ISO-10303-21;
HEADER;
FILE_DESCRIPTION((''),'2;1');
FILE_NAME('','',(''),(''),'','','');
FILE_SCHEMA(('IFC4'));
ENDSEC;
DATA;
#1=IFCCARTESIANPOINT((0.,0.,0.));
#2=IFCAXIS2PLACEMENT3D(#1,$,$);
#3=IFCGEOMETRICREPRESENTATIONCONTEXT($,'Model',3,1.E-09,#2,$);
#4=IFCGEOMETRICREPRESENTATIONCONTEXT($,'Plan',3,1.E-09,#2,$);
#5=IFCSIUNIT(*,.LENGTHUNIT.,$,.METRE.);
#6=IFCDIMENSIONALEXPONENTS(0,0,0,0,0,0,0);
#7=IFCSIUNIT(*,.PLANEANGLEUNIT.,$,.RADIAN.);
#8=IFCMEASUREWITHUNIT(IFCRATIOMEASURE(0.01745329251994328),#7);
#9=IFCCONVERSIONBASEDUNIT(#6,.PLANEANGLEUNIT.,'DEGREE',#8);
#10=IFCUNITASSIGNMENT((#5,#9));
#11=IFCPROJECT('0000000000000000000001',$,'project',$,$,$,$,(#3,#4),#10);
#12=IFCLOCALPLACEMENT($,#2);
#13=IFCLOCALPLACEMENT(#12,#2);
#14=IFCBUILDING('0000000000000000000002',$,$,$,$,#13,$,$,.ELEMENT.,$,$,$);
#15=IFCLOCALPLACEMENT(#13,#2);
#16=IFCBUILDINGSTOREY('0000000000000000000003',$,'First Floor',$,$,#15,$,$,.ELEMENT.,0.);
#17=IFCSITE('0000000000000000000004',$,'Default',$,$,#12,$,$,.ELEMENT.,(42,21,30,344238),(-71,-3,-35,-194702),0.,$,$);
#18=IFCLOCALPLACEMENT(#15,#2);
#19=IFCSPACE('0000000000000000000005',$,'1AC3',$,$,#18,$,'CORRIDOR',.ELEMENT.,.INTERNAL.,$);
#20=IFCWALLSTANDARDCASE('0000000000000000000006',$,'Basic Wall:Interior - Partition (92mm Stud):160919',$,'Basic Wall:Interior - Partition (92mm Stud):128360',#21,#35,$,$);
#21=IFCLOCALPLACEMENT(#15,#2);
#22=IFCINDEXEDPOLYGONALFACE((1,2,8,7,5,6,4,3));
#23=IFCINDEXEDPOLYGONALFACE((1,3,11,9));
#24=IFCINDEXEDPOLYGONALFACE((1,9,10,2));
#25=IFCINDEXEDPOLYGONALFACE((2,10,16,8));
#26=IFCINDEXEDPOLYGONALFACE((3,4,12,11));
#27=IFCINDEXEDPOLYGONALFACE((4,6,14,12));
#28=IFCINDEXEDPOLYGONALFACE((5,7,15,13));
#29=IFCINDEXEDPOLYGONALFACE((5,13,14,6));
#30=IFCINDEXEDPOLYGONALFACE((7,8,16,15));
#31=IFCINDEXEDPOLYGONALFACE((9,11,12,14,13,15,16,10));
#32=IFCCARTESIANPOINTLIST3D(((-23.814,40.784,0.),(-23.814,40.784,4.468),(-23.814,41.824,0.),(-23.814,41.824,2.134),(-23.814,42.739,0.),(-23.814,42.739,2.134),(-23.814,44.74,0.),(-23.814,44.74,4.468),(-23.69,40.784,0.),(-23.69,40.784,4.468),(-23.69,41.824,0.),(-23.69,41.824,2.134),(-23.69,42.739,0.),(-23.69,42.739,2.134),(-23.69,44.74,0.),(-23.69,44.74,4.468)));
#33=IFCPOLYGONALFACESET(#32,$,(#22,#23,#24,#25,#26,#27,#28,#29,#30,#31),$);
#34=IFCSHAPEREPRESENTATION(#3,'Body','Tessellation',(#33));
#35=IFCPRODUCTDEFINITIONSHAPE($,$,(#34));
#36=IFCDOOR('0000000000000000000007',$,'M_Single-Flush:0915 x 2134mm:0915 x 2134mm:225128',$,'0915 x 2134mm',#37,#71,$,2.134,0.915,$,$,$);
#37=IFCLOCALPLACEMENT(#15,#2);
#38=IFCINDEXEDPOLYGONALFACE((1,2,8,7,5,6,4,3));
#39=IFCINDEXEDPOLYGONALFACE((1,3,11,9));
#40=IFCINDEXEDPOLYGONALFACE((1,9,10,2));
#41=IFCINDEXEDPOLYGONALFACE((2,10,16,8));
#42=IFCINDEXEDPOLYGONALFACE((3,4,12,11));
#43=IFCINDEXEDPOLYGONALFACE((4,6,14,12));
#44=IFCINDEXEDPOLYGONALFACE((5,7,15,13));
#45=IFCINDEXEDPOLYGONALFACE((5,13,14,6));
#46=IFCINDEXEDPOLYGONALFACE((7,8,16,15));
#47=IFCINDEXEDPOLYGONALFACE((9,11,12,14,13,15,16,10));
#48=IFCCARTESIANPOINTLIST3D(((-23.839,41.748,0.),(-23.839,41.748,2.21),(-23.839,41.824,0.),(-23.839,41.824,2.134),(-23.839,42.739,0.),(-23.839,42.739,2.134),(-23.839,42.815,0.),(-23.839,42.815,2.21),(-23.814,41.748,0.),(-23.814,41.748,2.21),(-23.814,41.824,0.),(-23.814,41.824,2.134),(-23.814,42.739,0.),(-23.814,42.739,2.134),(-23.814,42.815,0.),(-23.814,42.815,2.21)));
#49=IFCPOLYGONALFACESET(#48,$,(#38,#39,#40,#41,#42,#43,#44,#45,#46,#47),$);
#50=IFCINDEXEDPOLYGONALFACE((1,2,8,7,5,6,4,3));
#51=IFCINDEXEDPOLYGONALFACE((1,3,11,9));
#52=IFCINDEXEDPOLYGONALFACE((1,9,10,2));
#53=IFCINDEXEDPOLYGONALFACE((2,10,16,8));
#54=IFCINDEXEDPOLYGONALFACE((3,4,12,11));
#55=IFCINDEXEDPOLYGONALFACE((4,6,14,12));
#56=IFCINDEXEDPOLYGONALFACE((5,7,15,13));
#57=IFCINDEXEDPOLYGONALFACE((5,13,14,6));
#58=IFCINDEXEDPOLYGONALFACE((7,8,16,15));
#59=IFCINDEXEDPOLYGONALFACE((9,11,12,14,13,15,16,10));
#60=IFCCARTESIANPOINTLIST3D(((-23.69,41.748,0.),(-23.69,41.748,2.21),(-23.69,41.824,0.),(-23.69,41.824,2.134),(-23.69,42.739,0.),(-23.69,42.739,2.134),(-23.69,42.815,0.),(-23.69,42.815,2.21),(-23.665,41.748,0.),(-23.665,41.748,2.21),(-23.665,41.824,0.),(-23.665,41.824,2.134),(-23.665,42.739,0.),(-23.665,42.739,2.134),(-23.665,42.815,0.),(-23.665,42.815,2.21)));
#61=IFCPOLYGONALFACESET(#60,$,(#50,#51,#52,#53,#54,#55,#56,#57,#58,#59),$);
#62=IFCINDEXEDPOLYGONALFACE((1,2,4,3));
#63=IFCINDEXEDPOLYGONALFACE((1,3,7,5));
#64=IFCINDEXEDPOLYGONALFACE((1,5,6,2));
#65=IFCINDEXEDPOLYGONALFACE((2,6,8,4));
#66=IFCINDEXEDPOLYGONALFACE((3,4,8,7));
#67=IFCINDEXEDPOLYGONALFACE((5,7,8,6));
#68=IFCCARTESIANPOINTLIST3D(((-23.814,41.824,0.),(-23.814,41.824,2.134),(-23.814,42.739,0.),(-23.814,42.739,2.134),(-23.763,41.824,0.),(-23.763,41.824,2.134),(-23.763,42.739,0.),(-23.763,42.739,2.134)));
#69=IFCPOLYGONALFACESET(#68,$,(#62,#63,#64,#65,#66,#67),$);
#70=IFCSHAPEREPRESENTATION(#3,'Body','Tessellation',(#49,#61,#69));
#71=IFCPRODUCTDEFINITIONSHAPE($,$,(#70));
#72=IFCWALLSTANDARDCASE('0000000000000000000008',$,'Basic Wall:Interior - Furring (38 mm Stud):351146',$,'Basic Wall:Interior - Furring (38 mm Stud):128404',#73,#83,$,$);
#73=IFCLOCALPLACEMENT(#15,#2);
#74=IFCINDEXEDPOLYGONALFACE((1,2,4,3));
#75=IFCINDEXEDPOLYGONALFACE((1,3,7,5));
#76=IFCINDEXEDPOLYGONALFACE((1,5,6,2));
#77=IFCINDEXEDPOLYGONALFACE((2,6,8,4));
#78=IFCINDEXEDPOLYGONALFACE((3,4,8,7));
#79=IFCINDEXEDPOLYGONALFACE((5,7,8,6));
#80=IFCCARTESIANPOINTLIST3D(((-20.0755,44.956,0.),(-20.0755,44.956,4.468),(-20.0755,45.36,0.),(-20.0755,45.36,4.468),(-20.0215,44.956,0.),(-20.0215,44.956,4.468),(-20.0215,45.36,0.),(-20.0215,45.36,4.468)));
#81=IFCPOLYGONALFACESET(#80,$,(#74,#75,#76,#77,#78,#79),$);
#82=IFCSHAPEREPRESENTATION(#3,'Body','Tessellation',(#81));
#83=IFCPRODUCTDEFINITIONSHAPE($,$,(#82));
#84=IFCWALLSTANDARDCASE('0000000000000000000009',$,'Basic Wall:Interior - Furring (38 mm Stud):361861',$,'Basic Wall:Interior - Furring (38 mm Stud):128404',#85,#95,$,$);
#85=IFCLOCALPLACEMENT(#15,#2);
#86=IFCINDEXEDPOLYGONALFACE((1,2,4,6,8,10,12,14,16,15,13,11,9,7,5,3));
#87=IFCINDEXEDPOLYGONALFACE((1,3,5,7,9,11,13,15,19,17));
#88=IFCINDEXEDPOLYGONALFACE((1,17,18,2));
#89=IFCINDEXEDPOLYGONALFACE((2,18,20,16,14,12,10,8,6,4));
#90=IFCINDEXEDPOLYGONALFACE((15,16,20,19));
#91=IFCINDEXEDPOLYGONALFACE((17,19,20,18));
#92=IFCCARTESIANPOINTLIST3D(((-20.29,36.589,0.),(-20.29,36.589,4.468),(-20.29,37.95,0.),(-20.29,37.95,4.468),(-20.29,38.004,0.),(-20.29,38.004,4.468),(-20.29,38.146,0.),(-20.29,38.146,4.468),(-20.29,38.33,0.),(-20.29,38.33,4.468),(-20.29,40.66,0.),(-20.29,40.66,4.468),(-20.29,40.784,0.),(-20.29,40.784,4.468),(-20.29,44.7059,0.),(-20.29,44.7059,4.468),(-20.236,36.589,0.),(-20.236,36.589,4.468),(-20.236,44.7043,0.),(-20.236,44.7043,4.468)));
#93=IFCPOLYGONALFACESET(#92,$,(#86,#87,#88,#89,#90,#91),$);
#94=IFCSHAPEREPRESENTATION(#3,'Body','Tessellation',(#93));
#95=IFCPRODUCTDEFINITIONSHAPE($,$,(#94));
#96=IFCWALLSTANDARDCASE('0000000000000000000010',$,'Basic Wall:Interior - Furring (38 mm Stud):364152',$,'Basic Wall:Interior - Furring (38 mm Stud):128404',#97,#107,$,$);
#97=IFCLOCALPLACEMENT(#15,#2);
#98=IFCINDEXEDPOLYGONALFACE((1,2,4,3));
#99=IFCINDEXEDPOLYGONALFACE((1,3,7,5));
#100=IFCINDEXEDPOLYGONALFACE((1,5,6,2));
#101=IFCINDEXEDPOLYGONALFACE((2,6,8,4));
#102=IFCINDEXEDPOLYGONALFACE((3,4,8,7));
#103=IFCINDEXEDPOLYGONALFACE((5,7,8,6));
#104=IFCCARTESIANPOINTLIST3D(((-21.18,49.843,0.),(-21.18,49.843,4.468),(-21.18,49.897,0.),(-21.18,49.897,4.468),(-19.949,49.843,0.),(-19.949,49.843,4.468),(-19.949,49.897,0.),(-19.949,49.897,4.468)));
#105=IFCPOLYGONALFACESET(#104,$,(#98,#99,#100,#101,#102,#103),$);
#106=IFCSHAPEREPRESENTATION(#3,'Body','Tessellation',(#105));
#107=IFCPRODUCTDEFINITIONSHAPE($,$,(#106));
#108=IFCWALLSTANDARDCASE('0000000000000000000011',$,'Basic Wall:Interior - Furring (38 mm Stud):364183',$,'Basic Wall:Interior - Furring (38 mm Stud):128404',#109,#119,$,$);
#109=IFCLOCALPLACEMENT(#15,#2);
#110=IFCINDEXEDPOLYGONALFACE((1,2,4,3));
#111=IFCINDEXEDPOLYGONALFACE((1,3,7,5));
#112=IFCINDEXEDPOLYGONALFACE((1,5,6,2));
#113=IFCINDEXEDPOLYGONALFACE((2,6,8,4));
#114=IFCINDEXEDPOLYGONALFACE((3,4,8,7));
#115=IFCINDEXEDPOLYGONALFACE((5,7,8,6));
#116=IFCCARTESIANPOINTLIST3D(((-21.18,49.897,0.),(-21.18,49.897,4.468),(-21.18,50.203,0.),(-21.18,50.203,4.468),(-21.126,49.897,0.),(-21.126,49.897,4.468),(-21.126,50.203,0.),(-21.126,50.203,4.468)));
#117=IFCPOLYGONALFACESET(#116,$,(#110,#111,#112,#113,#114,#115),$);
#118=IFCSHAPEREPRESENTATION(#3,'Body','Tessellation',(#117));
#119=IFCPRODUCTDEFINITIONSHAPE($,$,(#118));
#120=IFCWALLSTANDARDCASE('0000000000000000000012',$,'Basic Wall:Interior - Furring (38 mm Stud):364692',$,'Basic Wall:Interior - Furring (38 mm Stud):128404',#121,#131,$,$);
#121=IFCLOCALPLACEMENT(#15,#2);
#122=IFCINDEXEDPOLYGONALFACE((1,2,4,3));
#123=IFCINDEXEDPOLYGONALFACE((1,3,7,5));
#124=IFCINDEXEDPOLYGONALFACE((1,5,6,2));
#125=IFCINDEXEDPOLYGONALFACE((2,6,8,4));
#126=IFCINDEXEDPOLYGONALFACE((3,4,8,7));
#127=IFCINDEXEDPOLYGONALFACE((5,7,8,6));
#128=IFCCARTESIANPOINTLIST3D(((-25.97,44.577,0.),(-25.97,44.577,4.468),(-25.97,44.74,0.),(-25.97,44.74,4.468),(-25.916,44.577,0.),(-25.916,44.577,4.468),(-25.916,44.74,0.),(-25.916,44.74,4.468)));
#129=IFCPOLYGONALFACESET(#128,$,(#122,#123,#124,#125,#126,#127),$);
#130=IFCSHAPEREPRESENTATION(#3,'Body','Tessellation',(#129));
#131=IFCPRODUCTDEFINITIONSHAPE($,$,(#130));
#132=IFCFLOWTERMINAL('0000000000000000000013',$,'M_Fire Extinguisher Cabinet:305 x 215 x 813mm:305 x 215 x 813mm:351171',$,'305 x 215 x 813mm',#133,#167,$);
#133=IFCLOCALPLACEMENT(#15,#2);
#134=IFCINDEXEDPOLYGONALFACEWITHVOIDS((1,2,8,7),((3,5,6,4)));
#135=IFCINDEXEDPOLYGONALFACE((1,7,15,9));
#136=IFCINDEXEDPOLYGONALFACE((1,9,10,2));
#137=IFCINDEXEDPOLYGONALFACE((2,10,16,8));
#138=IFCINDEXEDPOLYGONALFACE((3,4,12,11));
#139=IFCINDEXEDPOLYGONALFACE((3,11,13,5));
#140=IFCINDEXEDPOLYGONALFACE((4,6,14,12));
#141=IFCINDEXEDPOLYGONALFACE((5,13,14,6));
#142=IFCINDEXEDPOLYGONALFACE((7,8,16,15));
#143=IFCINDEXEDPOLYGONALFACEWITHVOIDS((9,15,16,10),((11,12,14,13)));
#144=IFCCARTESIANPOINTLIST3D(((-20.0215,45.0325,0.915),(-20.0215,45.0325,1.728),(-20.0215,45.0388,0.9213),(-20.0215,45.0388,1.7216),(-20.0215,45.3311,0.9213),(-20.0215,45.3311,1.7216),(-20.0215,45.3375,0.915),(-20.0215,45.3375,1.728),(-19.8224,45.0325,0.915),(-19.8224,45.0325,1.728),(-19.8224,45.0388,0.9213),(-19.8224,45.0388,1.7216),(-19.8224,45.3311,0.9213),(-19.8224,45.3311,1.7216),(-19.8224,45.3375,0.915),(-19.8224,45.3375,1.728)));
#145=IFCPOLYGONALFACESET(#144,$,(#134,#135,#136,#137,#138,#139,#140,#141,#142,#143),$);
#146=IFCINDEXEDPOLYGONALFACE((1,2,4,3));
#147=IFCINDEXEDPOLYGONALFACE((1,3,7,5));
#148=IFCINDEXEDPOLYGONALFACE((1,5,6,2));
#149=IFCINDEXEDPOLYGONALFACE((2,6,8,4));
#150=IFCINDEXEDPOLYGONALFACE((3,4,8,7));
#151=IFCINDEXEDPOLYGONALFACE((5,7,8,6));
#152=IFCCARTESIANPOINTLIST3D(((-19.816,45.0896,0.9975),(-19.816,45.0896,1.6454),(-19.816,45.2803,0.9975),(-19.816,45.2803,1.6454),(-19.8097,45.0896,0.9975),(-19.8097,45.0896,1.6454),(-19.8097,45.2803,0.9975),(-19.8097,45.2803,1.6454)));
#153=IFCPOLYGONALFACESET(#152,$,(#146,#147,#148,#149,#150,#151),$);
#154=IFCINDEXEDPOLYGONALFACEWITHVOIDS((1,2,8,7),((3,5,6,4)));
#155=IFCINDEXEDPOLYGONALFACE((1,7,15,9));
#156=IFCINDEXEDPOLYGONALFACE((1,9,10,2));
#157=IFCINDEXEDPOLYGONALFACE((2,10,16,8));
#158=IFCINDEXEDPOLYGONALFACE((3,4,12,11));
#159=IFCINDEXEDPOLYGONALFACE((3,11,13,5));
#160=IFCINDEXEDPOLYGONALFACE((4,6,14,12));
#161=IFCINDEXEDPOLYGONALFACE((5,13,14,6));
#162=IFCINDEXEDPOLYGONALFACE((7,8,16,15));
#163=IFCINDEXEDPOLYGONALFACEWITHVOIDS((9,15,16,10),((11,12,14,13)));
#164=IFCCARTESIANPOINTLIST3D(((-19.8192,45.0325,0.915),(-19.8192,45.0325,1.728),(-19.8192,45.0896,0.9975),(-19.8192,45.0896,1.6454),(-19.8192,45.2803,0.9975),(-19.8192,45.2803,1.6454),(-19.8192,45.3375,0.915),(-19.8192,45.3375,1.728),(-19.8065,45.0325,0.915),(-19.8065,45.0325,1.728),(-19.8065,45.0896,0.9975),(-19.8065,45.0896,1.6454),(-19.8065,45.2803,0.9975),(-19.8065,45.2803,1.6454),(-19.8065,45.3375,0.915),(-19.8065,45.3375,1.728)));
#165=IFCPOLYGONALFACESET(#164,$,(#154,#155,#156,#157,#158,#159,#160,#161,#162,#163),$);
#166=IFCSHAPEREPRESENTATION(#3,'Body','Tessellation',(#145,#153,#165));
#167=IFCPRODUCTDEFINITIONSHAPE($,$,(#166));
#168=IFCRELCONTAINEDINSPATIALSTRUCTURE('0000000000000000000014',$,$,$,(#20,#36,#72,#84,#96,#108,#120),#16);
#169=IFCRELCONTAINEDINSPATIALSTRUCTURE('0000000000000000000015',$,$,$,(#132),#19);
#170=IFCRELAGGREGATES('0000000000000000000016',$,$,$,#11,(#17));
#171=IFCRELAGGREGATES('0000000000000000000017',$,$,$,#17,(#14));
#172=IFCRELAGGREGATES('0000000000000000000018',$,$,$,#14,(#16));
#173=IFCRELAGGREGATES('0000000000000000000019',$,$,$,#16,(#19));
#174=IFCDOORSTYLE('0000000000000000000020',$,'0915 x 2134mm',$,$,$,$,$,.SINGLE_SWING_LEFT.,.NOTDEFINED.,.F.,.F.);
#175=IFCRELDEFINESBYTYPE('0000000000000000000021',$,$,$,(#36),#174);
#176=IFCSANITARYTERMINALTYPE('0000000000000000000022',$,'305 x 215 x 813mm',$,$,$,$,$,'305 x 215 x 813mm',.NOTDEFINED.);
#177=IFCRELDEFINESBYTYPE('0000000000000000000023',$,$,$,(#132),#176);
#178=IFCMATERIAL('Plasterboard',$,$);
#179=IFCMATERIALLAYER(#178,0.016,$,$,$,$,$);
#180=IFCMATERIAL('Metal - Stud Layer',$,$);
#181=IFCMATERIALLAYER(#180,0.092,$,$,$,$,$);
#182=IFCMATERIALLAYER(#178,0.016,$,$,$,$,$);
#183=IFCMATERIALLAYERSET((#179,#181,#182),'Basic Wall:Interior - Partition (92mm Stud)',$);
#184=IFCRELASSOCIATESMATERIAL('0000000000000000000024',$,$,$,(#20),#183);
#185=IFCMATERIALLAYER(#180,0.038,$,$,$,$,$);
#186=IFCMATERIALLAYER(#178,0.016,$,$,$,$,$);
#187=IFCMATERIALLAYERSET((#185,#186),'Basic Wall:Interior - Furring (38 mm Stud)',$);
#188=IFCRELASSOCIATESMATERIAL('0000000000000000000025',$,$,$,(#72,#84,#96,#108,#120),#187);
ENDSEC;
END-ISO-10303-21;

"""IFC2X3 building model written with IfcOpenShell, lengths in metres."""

from ifc_helpers import new_model, entity, si_unit, converted_unit, frame, frame_2d, origin, origin_2d_with_axis, place, context, project, spatial, polyline, rectangle, outline, extrude, source, transform, mapped, material, layer, layer_set, layer_usage, type_object, type_shapes, element, fill, save


model = new_model("IFC2X3")

# Units and contexts
model_context = context("Model", 3, precision=1e-09, world=origin())
plan_context = context("Plan", 3, precision=1e-09, world=origin())
ifc_project = project(units=[si_unit("LENGTHUNIT", "METRE"), converted_unit("PLANEANGLEUNIT", "DEGREE", entity("IfcRatioMeasure", 0.01745329251994328), si_unit("PLANEANGLEUNIT", "RADIAN"), dimensions=[0, 0, 0, 0, 0, 0, 0])], contexts=[model_context, plan_context])

# Site, building, storey
site_placement = place(None, origin())
site = spatial("IfcSite", under=ifc_project, at=site_placement, Name="Default", CompositionType="ELEMENT", RefLatitude=(42, 21, 30, 344238), RefLongitude=(-71, -3, -35, -194702), RefElevation=0.0)
building_placement = place(site_placement, origin())
building = spatial("IfcBuilding", under=site, at=building_placement, CompositionType="ELEMENT")
storey_placement = place(building_placement, origin())
storey = spatial("IfcBuildingStorey", under=building, at=storey_placement, Name="First Floor", CompositionType="ELEMENT", Elevation=0.0)

# Shared definitions
ifc_material_1 = material(Name="Plasterboard")
ifc_layer_1 = layer(ifc_material_1, 0.016)
ifc_material_2 = material(Name="Metal - Stud Layer")
ifc_layer_2 = layer(ifc_material_2, 0.092)
ifc_layer_3 = layer(ifc_material_1, 0.016)
ifc_layer_set_1 = layer_set([ifc_layer_1, ifc_layer_2, ifc_layer_3], Name="Basic Wall:Interior - Partition (92mm Stud)")

# Shared definitions
ifc_layer_4 = layer(ifc_material_2, 0.038)
ifc_layer_5 = layer(ifc_material_1, 0.016)
ifc_layer_set_2 = layer_set([ifc_layer_4, ifc_layer_5], Name="Basic Wall:Interior - Furring (38 mm Stud)")

# Wall, opening, door
ifc_layer_usage_1 = layer_usage(ifc_layer_set_1, "AXIS2", "NEGATIVE", 0.062)
wall_1_placement = place(storey_placement, frame((-23.752, 44.74, 0.0), z_axis=(0.0, 0.0, 1.0), x_axis=(0.0, -1.0, 0.0)))
wall_1 = element("IfcWallStandardCase", 1, at=wall_1_placement, inside=storey, material=ifc_layer_usage_1, Name="Basic Wall:Interior - Partition (92mm Stud):160919", ObjectType="Basic Wall:Interior - Partition (92mm Stud):128360", context=model_context, shape_type="SweptSolid", body=[
    extrude(rectangle(XDim=3.956, YDim=0.124, at=frame_2d((1.978, 0.0), x_axis=(-1.0, 0.0))), origin(), (0.0, 0.0, 1.0), 4.468),
])
opening_1_placement = place(wall_1_placement, frame((2.916, 0.062, 0.0)))
opening_1 = element("IfcOpeningElement", 2, at=opening_1_placement, cuts=wall_1, ObjectType="Opening", context=model_context, shape_type="SweptSolid", body=[
    extrude(rectangle(XDim=0.915, YDim=2.134, at=frame_2d((1.067, 0.4575), x_axis=(0.0, -1.0))), frame((0.0, 0.0, 0.0), z_axis=(0.0, -1.0, 0.0), x_axis=(0.0, 0.0, 1.0)), (0.0, 0.0, 1.0), 0.124),
])
door_style_1 = type_object("IfcDoorStyle", Name="0915 x 2134mm", ConstructionType="NOTDEFINED", OperationType="SINGLE_SWING_LEFT", ParameterTakesPrecedence=False, Sizeable=False)
shared_shape_1 = source(origin(), model_context, "Body", "SweptSolid", [
    extrude(outline(polyline([(-0.5335, -1.124), (0.5335, -1.124), (0.5335, 1.086), (0.4575, 1.086), (0.4575, -1.048), (-0.4575, -1.048), (-0.4575, 1.086), (-0.5335, 1.086), (-0.5335, -1.124)])), frame((0.4575, 0.149, 1.086), z_axis=(0.0, -1.0, 0.0), x_axis=(-1.0, 0.0, 0.0)), (0.0, 0.0, 1.0), 0.025),
    extrude(outline(polyline([(-1.124, -0.5335), (1.086, -0.5335), (1.086, -0.4575), (-1.048, -0.4575), (-1.048, 0.4575), (1.086, 0.4575), (1.086, 0.5335), (-1.124, 0.5335), (-1.124, -0.5335)])), frame((0.4575, 0.0, 1.086), z_axis=(0.0, -1.0, 0.0), x_axis=(0.0, 0.0, -1.0)), (0.0, 0.0, 1.0), 0.025),
    extrude(rectangle(XDim=0.915, YDim=0.051, at=origin_2d_with_axis()), frame((0.4575, 0.0985, 0.0)), (0.0, 0.0, 1.0), 2.134),
])
type_shapes(door_style_1, [shared_shape_1])
door_1_placement = place(opening_1_placement, frame((0.0, 0.0, 0.0), z_axis=(0.0, 0.0, 1.0), x_axis=(-1.0, 0.0, 0.0)))
door_1 = element("IfcDoor", 3, at=door_1_placement, inside=storey, type_object=door_style_1, Name="M_Single-Flush:0915 x 2134mm:0915 x 2134mm:225128", ObjectType="0915 x 2134mm", OverallHeight=2.134, OverallWidth=0.915, context=model_context, shape_type="MappedRepresentation", body=[
    mapped(shared_shape_1, transform((0.0, 0.0, 0.0), scale=1.0)),
])
fill(opening_1, door_1)

# Walls
ifc_layer_usage_2 = layer_usage(ifc_layer_set_2, "AXIS2", "POSITIVE", -0.027)
wall_2_placement = place(storey_placement, frame((-20.0485, 45.36, 0.0), z_axis=(0.0, 0.0, 1.0), x_axis=(0.0, -1.0, 0.0)))
element("IfcWallStandardCase", 4, at=wall_2_placement, inside=storey, material=ifc_layer_usage_2, Name="Basic Wall:Interior - Furring (38 mm Stud):351146", ObjectType="Basic Wall:Interior - Furring (38 mm Stud):128404", context=model_context, shape_type="SweptSolid", body=[
    extrude(rectangle(XDim=0.404, YDim=0.054, at=frame_2d((0.202, 0.0), x_axis=(-1.0, 0.0))), origin(), (0.0, 0.0, 1.0), 4.468),
])
ifc_layer_usage_3 = layer_usage(ifc_layer_set_2, "AXIS2", "NEGATIVE", 0.027)
wall_3_placement = place(storey_placement, frame((-20.263, 44.7059, 0.0), z_axis=(0.0, 0.0, 1.0), x_axis=(0.0, -1.0, 0.0)))
element("IfcWallStandardCase", 5, at=wall_3_placement, inside=storey, material=ifc_layer_usage_3, Name="Basic Wall:Interior - Furring (38 mm Stud):361861", ObjectType="Basic Wall:Interior - Furring (38 mm Stud):128404", context=model_context, shape_type="SweptSolid", body=[
    extrude(outline(polyline([(8.1169, -0.027), (8.1169, 0.027), (0.0016, 0.027), (0.0, -0.027), (3.9219, -0.027), (4.0459, -0.027), (6.3759, -0.027), (6.5599, -0.027), (6.7019, -0.027), (6.7559, -0.027), (8.1169, -0.027)])), origin(), (0.0, 0.0, 1.0), 4.468),
])
ifc_layer_usage_4 = layer_usage(ifc_layer_set_2, "AXIS2", "POSITIVE", -0.027)
wall_4_placement = place(storey_placement, frame((-19.949, 49.87, 0.0), z_axis=(0.0, 0.0, 1.0), x_axis=(-1.0, 0.0, 0.0)))
element("IfcWallStandardCase", 6, at=wall_4_placement, inside=storey, material=ifc_layer_usage_4, Name="Basic Wall:Interior - Furring (38 mm Stud):364152", ObjectType="Basic Wall:Interior - Furring (38 mm Stud):128404", context=model_context, shape_type="SweptSolid", body=[
    extrude(rectangle(XDim=1.231, YDim=0.054, at=frame_2d((0.6155, 0.0), x_axis=(-1.0, 0.0))), origin(), (0.0, 0.0, 1.0), 4.468),
])
ifc_layer_usage_5 = layer_usage(ifc_layer_set_2, "AXIS2", "POSITIVE", -0.027)
wall_5_placement = place(storey_placement, frame((-21.153, 49.897, 0.0), z_axis=(0.0, 0.0, 1.0), x_axis=(0.0, 1.0, 0.0)))
element("IfcWallStandardCase", 7, at=wall_5_placement, inside=storey, material=ifc_layer_usage_5, Name="Basic Wall:Interior - Furring (38 mm Stud):364183", ObjectType="Basic Wall:Interior - Furring (38 mm Stud):128404", context=model_context, shape_type="SweptSolid", body=[
    extrude(rectangle(XDim=0.306, YDim=0.054, at=frame_2d((0.153, 0.0), x_axis=(-1.0, 0.0))), origin(), (0.0, 0.0, 1.0), 4.468),
])
ifc_layer_usage_6 = layer_usage(ifc_layer_set_2, "AXIS2", "NEGATIVE", 0.027)
wall_6_placement = place(storey_placement, frame((-25.943, 44.577, 0.0), z_axis=(0.0, 0.0, 1.0), x_axis=(0.0, 1.0, 0.0)))
element("IfcWallStandardCase", 8, at=wall_6_placement, inside=storey, material=ifc_layer_usage_6, Name="Basic Wall:Interior - Furring (38 mm Stud):364692", ObjectType="Basic Wall:Interior - Furring (38 mm Stud):128404", context=model_context, shape_type="SweptSolid", body=[
    extrude(rectangle(XDim=0.163, YDim=0.054, at=frame_2d((0.0815, 0.0), x_axis=(-1.0, 0.0))), origin(), (0.0, 0.0, 1.0), 4.468),
])

# Shared definitions
space_placement = place(storey_placement, origin())
space = spatial("IfcSpace", under=storey, at=space_placement, Name="1AC3", LongName="CORRIDOR", CompositionType="ELEMENT", InteriorOrExteriorSpace="INTERNAL")

# Flow terminal
sanitary_terminal_type = type_object("IfcSanitaryTerminalType", Name="305 x 215 x 813mm", ElementType="305 x 215 x 813mm", PredefinedType="NOTDEFINED")
shared_shape_2 = source(origin(), model_context, "Body", "SweptSolid", [
    extrude(outline(polyline([(-0.1525, -0.4065), (0.1525, -0.4065), (0.1525, 0.4065), (-0.1525, 0.4065), (-0.1525, -0.4065)]), holes=[polyline([(-0.1462, -0.4001), (-0.1462, 0.4002), (0.1462, 0.4002), (0.1462, -0.4001), (-0.1462, -0.4001)])]), frame((-0.1096, 0.027, 1.3215), z_axis=(0.0, 1.0, 0.0), x_axis=(1.0, 0.0, 0.0)), (0.0, 0.0, 1.0), 0.1991),
    extrude(rectangle(XDim=0.0064, YDim=0.1907, at=origin_2d_with_axis()), frame((-0.1096, 0.2356, 0.9975), z_axis=(0.0, 0.0, 1.0), x_axis=(0.0, -1.0, 0.0)), (0.0, 0.0, 1.0), 0.6479),
    extrude(outline(polyline([(-0.1525, -0.4065), (0.1525, -0.4065), (0.1525, 0.4065), (-0.1525, 0.4065), (-0.1525, -0.4065)]), holes=[polyline([(-0.0953, -0.3239), (-0.0953, 0.324), (0.0954, 0.324), (0.0954, -0.3239), (-0.0953, -0.3239)])]), frame((-0.1096, 0.2293, 1.3215), z_axis=(0.0, 1.0, 0.0), x_axis=(1.0, 0.0, 0.0)), (0.0, 0.0, 1.0), 0.0127),
])
type_shapes(sanitary_terminal_type, [shared_shape_2])
flow_terminal_placement = place(space_placement, frame((-20.0485, 45.0754, 0.0), z_axis=(0.0, 0.0, 1.0), x_axis=(0.0, -1.0, 0.0)))
element("IfcFlowTerminal", 9, at=flow_terminal_placement, inside=space, type_object=sanitary_terminal_type, Name="M_Fire Extinguisher Cabinet:305 x 215 x 813mm:305 x 215 x 813mm:351171", ObjectType="305 x 215 x 813mm", context=model_context, shape_type="MappedRepresentation", body=[
    mapped(shared_shape_2, transform((0.0, 0.0, 0.0), scale=1.0)),
])

save(model, "model.ifc")
